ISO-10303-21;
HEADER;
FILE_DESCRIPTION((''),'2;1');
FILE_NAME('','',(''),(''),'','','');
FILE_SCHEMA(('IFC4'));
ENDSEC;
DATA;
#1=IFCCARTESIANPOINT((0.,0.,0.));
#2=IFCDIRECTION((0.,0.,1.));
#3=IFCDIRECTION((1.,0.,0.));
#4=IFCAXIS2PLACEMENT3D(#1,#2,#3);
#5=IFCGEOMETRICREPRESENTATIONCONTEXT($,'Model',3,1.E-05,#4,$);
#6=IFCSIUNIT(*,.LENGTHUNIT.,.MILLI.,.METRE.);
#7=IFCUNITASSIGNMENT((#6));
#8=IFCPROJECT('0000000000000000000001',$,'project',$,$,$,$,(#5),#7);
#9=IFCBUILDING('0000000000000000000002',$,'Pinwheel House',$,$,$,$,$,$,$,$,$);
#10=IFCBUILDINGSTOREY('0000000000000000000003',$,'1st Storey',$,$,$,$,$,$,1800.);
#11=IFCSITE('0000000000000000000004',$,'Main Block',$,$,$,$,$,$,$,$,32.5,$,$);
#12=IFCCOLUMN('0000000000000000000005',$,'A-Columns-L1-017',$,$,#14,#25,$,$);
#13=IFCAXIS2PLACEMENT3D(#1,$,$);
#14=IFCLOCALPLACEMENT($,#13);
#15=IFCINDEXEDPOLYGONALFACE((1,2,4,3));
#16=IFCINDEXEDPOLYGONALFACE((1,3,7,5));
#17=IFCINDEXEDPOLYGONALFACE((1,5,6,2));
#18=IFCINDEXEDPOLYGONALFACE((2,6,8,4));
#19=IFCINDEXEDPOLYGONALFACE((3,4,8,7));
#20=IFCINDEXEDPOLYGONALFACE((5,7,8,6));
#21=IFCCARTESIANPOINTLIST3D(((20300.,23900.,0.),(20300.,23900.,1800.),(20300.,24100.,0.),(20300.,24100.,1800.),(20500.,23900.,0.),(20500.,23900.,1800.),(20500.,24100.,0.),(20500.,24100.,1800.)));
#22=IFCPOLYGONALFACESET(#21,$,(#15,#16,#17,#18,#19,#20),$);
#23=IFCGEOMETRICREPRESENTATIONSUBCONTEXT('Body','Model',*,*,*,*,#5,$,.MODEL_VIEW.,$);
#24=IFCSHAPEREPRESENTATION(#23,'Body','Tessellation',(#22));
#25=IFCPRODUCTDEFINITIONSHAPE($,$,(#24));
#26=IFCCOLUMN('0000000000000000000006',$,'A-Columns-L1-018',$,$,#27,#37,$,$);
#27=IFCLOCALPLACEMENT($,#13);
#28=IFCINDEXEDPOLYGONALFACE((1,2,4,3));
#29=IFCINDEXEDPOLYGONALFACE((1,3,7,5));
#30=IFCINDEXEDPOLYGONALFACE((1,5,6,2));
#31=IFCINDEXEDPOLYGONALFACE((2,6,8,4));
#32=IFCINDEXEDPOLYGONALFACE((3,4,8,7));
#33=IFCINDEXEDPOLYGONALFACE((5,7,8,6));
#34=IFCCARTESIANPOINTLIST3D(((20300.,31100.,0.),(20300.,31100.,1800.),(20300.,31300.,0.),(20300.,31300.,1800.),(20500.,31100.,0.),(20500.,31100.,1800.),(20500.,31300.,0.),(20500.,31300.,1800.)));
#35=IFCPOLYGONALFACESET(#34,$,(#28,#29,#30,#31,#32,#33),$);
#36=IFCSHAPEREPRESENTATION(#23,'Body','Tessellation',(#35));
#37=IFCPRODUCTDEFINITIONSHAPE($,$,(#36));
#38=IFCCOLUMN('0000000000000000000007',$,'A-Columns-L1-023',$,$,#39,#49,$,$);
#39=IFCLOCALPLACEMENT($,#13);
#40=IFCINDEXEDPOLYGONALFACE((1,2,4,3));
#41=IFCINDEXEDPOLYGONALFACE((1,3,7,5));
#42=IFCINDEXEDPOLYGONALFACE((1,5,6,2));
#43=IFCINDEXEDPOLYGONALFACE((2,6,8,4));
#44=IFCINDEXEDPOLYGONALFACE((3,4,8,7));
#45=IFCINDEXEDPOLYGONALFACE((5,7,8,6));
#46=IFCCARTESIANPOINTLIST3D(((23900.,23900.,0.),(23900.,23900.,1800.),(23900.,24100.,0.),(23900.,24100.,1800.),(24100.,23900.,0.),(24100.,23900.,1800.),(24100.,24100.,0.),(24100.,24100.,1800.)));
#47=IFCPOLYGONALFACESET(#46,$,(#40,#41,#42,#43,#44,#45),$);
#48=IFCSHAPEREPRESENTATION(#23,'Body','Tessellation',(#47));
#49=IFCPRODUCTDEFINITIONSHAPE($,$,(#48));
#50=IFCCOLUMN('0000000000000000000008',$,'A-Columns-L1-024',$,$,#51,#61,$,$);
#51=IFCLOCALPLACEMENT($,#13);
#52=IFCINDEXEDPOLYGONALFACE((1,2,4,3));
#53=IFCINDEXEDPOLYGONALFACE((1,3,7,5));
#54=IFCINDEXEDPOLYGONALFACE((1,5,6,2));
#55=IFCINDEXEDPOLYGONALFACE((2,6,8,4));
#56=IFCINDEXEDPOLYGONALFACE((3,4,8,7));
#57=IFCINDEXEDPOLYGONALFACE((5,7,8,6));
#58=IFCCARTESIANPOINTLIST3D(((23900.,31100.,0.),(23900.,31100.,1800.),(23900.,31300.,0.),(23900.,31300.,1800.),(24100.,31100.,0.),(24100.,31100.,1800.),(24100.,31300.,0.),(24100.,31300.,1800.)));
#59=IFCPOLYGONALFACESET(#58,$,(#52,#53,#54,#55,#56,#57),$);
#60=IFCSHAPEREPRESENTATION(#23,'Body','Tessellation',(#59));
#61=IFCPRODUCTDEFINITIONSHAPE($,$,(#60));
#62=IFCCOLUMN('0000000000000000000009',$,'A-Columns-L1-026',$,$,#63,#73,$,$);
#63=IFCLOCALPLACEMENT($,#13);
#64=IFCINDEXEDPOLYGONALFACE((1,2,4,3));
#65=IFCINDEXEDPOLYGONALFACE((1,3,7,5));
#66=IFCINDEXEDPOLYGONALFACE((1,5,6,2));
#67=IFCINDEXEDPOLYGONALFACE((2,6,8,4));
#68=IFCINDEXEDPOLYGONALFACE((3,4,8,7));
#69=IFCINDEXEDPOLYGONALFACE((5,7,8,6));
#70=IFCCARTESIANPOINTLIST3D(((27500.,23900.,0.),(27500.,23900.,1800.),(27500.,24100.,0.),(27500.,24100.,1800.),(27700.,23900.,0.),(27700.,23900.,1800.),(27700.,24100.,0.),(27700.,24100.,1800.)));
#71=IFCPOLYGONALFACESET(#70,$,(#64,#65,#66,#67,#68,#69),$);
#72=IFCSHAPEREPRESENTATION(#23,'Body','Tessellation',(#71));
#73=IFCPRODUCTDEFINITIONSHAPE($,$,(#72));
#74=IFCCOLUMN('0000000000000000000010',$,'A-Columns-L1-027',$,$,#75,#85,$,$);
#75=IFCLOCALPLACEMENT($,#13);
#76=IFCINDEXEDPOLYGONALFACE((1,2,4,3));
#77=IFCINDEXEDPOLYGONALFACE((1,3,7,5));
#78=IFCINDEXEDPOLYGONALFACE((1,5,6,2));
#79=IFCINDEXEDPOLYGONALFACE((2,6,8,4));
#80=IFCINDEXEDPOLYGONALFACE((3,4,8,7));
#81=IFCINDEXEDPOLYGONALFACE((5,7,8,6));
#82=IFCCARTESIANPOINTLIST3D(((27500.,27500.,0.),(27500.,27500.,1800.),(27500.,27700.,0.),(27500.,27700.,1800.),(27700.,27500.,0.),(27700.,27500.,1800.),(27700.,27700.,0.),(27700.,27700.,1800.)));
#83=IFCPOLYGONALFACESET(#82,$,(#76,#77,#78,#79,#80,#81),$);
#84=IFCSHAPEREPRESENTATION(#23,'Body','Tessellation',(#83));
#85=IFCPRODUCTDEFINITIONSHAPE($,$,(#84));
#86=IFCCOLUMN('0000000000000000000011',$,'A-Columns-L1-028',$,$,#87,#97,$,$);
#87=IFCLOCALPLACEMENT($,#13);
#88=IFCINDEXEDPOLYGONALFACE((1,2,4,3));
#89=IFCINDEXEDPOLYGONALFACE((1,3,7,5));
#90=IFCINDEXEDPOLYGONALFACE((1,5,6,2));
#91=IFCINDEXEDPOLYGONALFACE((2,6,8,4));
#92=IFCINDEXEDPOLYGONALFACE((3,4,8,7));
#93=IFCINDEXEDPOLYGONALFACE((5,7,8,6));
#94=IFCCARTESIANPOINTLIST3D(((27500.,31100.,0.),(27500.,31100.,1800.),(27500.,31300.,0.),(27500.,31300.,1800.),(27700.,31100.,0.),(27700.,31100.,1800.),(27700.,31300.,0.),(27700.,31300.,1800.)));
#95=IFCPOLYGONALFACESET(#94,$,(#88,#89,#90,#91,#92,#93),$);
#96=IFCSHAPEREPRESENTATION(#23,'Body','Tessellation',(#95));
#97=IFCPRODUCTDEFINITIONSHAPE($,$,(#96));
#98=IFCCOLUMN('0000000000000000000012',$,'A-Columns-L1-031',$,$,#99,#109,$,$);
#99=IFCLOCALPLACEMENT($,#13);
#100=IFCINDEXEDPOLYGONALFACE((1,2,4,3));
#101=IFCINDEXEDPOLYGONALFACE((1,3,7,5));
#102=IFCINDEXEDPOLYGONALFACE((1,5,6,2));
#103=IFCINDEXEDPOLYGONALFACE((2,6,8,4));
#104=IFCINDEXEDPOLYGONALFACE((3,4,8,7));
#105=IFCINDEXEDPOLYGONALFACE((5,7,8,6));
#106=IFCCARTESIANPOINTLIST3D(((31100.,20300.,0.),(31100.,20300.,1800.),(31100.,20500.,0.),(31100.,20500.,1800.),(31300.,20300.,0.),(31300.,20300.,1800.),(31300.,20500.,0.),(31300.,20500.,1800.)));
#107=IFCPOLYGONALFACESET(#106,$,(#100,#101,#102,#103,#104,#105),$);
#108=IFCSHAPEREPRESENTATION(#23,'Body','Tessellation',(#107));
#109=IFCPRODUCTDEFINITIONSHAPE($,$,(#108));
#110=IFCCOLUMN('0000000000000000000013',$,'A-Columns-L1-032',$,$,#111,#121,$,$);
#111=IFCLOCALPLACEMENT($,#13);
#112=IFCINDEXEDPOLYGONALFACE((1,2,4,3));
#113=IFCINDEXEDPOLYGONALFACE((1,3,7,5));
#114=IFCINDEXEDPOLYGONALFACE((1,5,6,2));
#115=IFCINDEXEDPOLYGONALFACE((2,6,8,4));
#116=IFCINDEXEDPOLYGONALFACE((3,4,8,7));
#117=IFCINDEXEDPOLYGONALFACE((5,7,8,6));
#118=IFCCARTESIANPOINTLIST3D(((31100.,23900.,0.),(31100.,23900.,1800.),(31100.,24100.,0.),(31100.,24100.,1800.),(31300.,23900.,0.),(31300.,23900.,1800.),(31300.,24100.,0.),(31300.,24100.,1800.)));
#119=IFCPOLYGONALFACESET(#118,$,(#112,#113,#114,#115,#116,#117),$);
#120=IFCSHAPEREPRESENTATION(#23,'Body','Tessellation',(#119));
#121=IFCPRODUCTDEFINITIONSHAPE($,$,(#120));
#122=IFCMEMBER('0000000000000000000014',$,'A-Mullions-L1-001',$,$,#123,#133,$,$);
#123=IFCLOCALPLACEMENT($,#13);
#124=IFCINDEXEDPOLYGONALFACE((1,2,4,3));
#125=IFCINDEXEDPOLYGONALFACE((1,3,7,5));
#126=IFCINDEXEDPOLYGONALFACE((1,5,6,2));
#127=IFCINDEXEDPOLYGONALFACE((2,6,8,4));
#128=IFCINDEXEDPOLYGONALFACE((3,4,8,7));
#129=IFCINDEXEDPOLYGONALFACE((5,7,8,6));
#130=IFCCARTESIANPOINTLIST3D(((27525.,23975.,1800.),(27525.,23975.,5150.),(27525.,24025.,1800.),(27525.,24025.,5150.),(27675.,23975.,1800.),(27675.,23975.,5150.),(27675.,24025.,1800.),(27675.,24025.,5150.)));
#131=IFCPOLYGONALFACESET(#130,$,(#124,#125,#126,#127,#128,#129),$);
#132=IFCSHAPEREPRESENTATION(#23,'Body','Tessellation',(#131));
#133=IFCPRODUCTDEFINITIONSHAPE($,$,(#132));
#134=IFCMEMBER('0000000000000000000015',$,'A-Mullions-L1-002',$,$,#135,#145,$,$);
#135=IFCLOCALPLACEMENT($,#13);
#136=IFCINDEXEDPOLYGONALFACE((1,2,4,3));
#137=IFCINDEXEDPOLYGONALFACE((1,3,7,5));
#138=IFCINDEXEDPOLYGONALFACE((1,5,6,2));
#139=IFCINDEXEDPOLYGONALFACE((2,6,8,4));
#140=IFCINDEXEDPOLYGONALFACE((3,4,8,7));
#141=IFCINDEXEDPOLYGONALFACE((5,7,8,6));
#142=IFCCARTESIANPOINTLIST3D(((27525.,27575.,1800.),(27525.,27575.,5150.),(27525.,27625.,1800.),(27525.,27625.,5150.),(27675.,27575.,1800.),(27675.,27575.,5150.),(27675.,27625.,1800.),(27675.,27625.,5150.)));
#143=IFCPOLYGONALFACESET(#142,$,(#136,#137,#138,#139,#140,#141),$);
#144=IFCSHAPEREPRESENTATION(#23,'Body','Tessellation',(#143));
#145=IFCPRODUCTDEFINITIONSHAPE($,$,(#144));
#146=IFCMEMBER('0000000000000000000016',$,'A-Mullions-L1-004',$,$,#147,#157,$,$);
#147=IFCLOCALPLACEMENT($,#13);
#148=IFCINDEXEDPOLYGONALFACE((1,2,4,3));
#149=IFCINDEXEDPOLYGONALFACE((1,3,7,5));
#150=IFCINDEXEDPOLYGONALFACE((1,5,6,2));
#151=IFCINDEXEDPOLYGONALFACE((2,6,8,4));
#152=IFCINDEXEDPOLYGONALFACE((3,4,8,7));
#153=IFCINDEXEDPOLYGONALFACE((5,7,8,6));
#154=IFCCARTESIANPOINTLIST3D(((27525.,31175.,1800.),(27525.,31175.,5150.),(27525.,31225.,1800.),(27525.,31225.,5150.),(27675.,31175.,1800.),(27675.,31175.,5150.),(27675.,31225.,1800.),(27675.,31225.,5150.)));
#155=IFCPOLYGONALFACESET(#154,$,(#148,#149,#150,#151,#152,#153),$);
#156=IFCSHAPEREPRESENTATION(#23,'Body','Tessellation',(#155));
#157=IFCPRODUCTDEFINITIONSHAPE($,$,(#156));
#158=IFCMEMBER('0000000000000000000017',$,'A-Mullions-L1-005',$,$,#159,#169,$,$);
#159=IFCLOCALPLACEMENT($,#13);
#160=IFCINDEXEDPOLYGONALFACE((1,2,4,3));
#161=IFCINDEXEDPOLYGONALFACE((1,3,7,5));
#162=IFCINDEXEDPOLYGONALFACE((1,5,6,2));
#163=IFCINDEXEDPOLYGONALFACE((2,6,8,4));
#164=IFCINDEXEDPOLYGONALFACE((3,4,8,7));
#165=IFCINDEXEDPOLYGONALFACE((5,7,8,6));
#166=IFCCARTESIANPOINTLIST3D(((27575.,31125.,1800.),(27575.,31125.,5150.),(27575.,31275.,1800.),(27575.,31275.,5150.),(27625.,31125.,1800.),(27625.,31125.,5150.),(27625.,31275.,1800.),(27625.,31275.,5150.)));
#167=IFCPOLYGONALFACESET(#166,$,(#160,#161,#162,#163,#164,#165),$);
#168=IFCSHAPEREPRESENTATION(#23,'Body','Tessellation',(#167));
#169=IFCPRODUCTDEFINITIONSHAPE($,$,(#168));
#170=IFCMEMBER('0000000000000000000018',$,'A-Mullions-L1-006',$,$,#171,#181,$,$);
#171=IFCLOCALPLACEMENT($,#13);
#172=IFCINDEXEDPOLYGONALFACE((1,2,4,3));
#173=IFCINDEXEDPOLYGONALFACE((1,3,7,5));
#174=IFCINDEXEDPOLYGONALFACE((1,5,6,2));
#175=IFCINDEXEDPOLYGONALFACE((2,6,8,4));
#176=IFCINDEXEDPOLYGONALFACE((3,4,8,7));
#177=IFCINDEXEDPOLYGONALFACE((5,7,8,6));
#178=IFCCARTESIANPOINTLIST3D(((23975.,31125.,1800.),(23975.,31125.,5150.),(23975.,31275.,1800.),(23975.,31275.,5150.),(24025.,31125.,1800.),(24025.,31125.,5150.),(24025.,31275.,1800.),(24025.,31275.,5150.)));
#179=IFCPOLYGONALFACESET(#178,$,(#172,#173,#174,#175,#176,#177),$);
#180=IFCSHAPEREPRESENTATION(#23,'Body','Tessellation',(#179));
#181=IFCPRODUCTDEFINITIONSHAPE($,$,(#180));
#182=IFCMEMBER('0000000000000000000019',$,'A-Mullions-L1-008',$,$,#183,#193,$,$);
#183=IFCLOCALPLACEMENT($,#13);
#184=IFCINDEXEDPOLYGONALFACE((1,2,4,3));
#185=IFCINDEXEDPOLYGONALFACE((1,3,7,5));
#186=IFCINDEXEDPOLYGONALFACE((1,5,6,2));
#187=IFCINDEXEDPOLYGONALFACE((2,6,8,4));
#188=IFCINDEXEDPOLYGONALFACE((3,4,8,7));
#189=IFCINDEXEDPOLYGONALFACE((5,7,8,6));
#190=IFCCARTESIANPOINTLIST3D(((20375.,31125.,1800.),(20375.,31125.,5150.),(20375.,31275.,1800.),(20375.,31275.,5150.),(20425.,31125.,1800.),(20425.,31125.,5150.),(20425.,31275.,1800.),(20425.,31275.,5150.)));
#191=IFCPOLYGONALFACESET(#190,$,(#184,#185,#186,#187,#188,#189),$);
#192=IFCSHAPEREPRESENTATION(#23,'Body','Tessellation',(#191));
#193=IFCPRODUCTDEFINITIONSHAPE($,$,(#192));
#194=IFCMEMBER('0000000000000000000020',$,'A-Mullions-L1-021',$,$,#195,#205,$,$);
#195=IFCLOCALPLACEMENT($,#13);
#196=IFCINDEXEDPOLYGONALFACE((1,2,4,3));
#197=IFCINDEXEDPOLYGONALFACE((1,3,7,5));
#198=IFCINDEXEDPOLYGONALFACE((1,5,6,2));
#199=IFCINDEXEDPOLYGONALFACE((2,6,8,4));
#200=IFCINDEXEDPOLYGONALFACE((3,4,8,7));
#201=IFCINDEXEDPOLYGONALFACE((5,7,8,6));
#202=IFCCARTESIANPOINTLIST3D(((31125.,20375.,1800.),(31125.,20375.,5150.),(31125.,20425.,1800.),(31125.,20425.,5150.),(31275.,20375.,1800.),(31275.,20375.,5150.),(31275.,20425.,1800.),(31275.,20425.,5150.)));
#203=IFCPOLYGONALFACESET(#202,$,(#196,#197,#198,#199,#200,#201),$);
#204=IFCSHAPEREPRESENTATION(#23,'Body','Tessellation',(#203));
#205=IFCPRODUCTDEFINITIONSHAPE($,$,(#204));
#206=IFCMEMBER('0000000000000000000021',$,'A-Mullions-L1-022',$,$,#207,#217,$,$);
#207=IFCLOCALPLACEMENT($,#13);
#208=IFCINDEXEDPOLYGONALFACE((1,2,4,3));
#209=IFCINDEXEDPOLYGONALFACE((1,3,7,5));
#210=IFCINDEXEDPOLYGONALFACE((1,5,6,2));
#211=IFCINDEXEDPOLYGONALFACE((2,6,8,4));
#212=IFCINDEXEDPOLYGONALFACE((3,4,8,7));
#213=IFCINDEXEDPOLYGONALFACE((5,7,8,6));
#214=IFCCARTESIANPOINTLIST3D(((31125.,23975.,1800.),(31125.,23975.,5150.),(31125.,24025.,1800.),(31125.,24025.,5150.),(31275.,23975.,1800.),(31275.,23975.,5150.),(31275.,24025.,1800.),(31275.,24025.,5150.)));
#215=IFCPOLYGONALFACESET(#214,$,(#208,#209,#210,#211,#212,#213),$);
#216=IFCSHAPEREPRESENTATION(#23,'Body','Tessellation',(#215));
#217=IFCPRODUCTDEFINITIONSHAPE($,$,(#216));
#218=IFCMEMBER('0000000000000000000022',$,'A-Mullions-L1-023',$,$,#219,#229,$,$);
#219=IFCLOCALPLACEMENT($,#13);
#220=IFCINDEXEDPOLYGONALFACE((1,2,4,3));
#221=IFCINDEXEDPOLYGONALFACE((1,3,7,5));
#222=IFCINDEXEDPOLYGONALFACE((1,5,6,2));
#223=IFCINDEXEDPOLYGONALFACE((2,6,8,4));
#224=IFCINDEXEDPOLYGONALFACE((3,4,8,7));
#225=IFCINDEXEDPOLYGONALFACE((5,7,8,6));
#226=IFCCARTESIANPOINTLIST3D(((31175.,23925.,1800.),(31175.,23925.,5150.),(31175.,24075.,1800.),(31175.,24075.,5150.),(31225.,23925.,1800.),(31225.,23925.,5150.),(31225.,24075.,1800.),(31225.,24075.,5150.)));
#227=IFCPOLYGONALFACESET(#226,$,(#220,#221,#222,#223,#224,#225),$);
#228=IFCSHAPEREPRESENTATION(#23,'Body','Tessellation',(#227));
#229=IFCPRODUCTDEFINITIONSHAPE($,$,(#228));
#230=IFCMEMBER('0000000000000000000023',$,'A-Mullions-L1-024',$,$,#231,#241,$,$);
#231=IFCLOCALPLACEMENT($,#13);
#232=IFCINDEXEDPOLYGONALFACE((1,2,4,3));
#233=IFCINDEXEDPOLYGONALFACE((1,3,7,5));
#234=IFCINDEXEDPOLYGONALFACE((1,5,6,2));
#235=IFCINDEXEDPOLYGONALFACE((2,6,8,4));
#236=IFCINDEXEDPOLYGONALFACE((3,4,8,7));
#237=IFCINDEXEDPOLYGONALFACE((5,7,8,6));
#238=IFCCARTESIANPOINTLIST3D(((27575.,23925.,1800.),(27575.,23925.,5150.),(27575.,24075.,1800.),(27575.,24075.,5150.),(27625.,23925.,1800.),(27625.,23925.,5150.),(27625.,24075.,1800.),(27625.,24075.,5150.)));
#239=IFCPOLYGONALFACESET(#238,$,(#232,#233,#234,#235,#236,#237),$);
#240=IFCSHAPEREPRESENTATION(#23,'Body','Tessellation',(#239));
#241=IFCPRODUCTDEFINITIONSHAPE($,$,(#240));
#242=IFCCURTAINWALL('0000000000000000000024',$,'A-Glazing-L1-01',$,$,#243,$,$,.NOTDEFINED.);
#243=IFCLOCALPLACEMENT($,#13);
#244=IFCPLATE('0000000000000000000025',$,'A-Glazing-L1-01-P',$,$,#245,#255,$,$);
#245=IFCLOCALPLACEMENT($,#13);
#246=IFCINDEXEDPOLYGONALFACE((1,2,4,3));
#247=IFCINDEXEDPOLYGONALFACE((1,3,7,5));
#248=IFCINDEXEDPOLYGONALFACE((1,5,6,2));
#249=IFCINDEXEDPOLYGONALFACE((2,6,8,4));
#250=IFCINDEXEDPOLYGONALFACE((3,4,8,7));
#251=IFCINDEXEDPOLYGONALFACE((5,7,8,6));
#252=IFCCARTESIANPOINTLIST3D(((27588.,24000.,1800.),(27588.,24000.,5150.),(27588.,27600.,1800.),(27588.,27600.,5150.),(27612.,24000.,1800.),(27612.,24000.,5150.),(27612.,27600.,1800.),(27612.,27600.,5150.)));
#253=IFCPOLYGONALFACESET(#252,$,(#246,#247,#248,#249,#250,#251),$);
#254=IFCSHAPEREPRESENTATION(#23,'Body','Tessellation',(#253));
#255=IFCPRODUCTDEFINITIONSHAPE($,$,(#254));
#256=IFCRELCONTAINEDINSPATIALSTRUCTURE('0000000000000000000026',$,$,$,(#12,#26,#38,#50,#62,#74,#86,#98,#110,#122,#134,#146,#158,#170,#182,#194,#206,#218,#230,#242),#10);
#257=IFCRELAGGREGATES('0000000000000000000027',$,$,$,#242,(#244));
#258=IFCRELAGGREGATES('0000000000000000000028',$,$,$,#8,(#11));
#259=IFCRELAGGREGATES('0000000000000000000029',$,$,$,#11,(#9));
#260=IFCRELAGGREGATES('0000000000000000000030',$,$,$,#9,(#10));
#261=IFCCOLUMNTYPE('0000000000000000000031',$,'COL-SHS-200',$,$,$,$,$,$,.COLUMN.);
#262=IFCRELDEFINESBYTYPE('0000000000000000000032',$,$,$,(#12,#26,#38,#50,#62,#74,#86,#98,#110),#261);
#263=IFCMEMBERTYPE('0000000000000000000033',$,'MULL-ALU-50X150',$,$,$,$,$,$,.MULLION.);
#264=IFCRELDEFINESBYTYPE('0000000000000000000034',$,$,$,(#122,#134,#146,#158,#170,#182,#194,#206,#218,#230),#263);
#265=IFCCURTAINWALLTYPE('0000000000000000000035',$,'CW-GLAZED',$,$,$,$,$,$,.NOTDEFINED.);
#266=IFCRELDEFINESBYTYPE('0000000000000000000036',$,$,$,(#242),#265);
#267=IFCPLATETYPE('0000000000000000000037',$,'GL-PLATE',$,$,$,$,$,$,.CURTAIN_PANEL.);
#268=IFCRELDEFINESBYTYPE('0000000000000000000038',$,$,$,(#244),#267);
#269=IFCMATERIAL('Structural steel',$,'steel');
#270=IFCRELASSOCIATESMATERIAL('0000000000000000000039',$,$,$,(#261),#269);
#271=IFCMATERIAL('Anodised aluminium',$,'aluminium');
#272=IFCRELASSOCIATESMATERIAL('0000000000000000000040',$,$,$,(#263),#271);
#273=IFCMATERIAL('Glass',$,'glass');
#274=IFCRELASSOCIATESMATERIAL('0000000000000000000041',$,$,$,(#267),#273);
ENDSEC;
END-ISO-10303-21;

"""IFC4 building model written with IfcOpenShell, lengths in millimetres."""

from ifc_helpers import new_model, si_unit, frame, origin_with_axes, place, context, subcontext, project, spatial, indexed_curve, outline, extrude, material, type_object, element, aggregate, save


model = new_model("IFC4")

# Units and contexts
model_context = context("Model", 3, precision=1e-05, world=origin_with_axes())
body_context = subcontext(model_context, "Body", "Model", "MODEL_VIEW")
ifc_project = project(units=[si_unit("LENGTHUNIT", "METRE", prefix="MILLI")], contexts=[model_context])

# Site, building, storey
site = spatial("IfcSite", under=ifc_project, Name="Main Block", RefElevation=32.5)
building = spatial("IfcBuilding", under=site, Name="Pinwheel House")
storey = spatial("IfcBuildingStorey", under=building, Name="1st Storey", Elevation=1800.0)

# Columns
ifc_material_1 = material(Name="Structural steel", Category="steel")
column_type = type_object("IfcColumnType", Name="COL-SHS-200", PredefinedType="COLUMN", material=ifc_material_1)
for number, where, z_axis, x_axis, name in (
    (1, (20400.0, 24000.0, 0.0), (0.0, 0.0, 1.0), (1.0, 0.0, 0.0), "A-Columns-L1-017"),
    (2, (20400.0, 31200.0, 0.0), (0.0, 0.0, 1.0), (1.0, 0.0, 0.0), "A-Columns-L1-018"),
    (3, (24000.0, 24000.0, 0.0), (0.0, 0.0, 1.0), (1.0, 0.0, 0.0), "A-Columns-L1-023"),
    (4, (24000.0, 31200.0, 0.0), (0.0, 0.0, 1.0), (1.0, 0.0, 0.0), "A-Columns-L1-024"),
    (5, (27600.0, 24000.0, 0.0), (0.0, 0.0, 1.0), (1.0, 0.0, 0.0), "A-Columns-L1-026"),
    (6, (27600.0, 27600.0, 0.0), (0.0, 0.0, 1.0), (1.0, 0.0, 0.0), "A-Columns-L1-027"),
    (7, (27600.0, 31200.0, 0.0), (0.0, 0.0, 1.0), (1.0, 0.0, 0.0), "A-Columns-L1-028"),
    (8, (31200.0, 20400.0, 0.0), (0.0, 0.0, 1.0), (1.0, 0.0, 0.0), "A-Columns-L1-031"),
    (9, (31200.0, 24000.0, 0.0), (0.0, 0.0, 1.0), (1.0, 0.0, 0.0), "A-Columns-L1-032"),
):
    element("IfcColumn", number, at=place(None, frame(where, z_axis=z_axis, x_axis=x_axis)), inside=storey, type_object=column_type, Name=name, context=body_context, shape_type="SweptSolid", body=[
        extrude(outline(indexed_curve([(-100.0, -100.0), (100.0, -100.0), (100.0, 100.0), (-100.0, 100.0)])), None, (0.0, 0.0, 1.0), 1800.0),
    ])

# Members
ifc_material_2 = material(Name="Anodised aluminium", Category="aluminium")
member_type = type_object("IfcMemberType", Name="MULL-ALU-50X150", PredefinedType="MULLION", material=ifc_material_2)
for number, where, z_axis, x_axis, name in (
    (10, (27600.0, 24000.0, 1800.0), (0.0, 0.0, 1.0), (0.0, 1.0, 0.0), "A-Mullions-L1-001"),
    (11, (27600.0, 27600.0, 1800.0), (0.0, 0.0, 1.0), (0.0, 1.0, 0.0), "A-Mullions-L1-002"),
    (12, (27600.0, 31200.0, 1800.0), (0.0, 0.0, 1.0), (0.0, 1.0, 0.0), "A-Mullions-L1-004"),
    (13, (27600.0, 31200.0, 1800.0), (0.0, 0.0, 1.0), (-1.0, 0.0, 0.0), "A-Mullions-L1-005"),
    (14, (24000.0, 31200.0, 1800.0), (0.0, 0.0, 1.0), (-1.0, 0.0, 0.0), "A-Mullions-L1-006"),
    (15, (20400.0, 31200.0, 1800.0), (0.0, 0.0, 1.0), (-1.0, 0.0, 0.0), "A-Mullions-L1-008"),
    (16, (31200.0, 20400.0, 1800.0), (0.0, 0.0, 1.0), (0.0, 1.0, 0.0), "A-Mullions-L1-021"),
    (17, (31200.0, 24000.0, 1800.0), (0.0, 0.0, 1.0), (0.0, 1.0, 0.0), "A-Mullions-L1-022"),
    (18, (31200.0, 24000.0, 1800.0), (0.0, 0.0, 1.0), (-1.0, 0.0, 0.0), "A-Mullions-L1-023"),
    (19, (27600.0, 24000.0, 1800.0), (0.0, 0.0, 1.0), (-1.0, 0.0, 0.0), "A-Mullions-L1-024"),
):
    element("IfcMember", number, at=place(None, frame(where, z_axis=z_axis, x_axis=x_axis)), inside=storey, type_object=member_type, Name=name, context=body_context, shape_type="SweptSolid", body=[
        extrude(outline(indexed_curve([(-25.0, -75.0), (25.0, -75.0), (25.0, 75.0), (-25.0, 75.0)])), None, (0.0, 0.0, 1.0), 3350.0),
    ])

# Curtain wall, plate
curtain_wall_type = type_object("IfcCurtainWallType", Name="CW-GLAZED", PredefinedType="NOTDEFINED")
curtain_wall_1 = element("IfcCurtainWall", 20, inside=storey, type_object=curtain_wall_type, Name="A-Glazing-L1-01", PredefinedType="NOTDEFINED")
ifc_material_3 = material(Name="Glass", Category="glass")
plate_type = type_object("IfcPlateType", Name="GL-PLATE", PredefinedType="CURTAIN_PANEL", material=ifc_material_3)
plate_1_placement = place(None, frame((27600.0, 25800.0, 1800.0), z_axis=(0.0, 0.0, 1.0), x_axis=(0.0, 1.0, 0.0)))
plate_1 = element("IfcPlate", 21, at=plate_1_placement, type_object=plate_type, Name="A-Glazing-L1-01-P", context=body_context, shape_type="SweptSolid", body=[
    extrude(outline(indexed_curve([(-1800.0, -12.0), (1800.0, -12.0), (1800.0, 12.0), (-1800.0, 12.0)])), None, (0.0, 0.0, 1.0), 3350.0),
])
aggregate(curtain_wall_1, [plate_1])

save(model, "model.ifc")
